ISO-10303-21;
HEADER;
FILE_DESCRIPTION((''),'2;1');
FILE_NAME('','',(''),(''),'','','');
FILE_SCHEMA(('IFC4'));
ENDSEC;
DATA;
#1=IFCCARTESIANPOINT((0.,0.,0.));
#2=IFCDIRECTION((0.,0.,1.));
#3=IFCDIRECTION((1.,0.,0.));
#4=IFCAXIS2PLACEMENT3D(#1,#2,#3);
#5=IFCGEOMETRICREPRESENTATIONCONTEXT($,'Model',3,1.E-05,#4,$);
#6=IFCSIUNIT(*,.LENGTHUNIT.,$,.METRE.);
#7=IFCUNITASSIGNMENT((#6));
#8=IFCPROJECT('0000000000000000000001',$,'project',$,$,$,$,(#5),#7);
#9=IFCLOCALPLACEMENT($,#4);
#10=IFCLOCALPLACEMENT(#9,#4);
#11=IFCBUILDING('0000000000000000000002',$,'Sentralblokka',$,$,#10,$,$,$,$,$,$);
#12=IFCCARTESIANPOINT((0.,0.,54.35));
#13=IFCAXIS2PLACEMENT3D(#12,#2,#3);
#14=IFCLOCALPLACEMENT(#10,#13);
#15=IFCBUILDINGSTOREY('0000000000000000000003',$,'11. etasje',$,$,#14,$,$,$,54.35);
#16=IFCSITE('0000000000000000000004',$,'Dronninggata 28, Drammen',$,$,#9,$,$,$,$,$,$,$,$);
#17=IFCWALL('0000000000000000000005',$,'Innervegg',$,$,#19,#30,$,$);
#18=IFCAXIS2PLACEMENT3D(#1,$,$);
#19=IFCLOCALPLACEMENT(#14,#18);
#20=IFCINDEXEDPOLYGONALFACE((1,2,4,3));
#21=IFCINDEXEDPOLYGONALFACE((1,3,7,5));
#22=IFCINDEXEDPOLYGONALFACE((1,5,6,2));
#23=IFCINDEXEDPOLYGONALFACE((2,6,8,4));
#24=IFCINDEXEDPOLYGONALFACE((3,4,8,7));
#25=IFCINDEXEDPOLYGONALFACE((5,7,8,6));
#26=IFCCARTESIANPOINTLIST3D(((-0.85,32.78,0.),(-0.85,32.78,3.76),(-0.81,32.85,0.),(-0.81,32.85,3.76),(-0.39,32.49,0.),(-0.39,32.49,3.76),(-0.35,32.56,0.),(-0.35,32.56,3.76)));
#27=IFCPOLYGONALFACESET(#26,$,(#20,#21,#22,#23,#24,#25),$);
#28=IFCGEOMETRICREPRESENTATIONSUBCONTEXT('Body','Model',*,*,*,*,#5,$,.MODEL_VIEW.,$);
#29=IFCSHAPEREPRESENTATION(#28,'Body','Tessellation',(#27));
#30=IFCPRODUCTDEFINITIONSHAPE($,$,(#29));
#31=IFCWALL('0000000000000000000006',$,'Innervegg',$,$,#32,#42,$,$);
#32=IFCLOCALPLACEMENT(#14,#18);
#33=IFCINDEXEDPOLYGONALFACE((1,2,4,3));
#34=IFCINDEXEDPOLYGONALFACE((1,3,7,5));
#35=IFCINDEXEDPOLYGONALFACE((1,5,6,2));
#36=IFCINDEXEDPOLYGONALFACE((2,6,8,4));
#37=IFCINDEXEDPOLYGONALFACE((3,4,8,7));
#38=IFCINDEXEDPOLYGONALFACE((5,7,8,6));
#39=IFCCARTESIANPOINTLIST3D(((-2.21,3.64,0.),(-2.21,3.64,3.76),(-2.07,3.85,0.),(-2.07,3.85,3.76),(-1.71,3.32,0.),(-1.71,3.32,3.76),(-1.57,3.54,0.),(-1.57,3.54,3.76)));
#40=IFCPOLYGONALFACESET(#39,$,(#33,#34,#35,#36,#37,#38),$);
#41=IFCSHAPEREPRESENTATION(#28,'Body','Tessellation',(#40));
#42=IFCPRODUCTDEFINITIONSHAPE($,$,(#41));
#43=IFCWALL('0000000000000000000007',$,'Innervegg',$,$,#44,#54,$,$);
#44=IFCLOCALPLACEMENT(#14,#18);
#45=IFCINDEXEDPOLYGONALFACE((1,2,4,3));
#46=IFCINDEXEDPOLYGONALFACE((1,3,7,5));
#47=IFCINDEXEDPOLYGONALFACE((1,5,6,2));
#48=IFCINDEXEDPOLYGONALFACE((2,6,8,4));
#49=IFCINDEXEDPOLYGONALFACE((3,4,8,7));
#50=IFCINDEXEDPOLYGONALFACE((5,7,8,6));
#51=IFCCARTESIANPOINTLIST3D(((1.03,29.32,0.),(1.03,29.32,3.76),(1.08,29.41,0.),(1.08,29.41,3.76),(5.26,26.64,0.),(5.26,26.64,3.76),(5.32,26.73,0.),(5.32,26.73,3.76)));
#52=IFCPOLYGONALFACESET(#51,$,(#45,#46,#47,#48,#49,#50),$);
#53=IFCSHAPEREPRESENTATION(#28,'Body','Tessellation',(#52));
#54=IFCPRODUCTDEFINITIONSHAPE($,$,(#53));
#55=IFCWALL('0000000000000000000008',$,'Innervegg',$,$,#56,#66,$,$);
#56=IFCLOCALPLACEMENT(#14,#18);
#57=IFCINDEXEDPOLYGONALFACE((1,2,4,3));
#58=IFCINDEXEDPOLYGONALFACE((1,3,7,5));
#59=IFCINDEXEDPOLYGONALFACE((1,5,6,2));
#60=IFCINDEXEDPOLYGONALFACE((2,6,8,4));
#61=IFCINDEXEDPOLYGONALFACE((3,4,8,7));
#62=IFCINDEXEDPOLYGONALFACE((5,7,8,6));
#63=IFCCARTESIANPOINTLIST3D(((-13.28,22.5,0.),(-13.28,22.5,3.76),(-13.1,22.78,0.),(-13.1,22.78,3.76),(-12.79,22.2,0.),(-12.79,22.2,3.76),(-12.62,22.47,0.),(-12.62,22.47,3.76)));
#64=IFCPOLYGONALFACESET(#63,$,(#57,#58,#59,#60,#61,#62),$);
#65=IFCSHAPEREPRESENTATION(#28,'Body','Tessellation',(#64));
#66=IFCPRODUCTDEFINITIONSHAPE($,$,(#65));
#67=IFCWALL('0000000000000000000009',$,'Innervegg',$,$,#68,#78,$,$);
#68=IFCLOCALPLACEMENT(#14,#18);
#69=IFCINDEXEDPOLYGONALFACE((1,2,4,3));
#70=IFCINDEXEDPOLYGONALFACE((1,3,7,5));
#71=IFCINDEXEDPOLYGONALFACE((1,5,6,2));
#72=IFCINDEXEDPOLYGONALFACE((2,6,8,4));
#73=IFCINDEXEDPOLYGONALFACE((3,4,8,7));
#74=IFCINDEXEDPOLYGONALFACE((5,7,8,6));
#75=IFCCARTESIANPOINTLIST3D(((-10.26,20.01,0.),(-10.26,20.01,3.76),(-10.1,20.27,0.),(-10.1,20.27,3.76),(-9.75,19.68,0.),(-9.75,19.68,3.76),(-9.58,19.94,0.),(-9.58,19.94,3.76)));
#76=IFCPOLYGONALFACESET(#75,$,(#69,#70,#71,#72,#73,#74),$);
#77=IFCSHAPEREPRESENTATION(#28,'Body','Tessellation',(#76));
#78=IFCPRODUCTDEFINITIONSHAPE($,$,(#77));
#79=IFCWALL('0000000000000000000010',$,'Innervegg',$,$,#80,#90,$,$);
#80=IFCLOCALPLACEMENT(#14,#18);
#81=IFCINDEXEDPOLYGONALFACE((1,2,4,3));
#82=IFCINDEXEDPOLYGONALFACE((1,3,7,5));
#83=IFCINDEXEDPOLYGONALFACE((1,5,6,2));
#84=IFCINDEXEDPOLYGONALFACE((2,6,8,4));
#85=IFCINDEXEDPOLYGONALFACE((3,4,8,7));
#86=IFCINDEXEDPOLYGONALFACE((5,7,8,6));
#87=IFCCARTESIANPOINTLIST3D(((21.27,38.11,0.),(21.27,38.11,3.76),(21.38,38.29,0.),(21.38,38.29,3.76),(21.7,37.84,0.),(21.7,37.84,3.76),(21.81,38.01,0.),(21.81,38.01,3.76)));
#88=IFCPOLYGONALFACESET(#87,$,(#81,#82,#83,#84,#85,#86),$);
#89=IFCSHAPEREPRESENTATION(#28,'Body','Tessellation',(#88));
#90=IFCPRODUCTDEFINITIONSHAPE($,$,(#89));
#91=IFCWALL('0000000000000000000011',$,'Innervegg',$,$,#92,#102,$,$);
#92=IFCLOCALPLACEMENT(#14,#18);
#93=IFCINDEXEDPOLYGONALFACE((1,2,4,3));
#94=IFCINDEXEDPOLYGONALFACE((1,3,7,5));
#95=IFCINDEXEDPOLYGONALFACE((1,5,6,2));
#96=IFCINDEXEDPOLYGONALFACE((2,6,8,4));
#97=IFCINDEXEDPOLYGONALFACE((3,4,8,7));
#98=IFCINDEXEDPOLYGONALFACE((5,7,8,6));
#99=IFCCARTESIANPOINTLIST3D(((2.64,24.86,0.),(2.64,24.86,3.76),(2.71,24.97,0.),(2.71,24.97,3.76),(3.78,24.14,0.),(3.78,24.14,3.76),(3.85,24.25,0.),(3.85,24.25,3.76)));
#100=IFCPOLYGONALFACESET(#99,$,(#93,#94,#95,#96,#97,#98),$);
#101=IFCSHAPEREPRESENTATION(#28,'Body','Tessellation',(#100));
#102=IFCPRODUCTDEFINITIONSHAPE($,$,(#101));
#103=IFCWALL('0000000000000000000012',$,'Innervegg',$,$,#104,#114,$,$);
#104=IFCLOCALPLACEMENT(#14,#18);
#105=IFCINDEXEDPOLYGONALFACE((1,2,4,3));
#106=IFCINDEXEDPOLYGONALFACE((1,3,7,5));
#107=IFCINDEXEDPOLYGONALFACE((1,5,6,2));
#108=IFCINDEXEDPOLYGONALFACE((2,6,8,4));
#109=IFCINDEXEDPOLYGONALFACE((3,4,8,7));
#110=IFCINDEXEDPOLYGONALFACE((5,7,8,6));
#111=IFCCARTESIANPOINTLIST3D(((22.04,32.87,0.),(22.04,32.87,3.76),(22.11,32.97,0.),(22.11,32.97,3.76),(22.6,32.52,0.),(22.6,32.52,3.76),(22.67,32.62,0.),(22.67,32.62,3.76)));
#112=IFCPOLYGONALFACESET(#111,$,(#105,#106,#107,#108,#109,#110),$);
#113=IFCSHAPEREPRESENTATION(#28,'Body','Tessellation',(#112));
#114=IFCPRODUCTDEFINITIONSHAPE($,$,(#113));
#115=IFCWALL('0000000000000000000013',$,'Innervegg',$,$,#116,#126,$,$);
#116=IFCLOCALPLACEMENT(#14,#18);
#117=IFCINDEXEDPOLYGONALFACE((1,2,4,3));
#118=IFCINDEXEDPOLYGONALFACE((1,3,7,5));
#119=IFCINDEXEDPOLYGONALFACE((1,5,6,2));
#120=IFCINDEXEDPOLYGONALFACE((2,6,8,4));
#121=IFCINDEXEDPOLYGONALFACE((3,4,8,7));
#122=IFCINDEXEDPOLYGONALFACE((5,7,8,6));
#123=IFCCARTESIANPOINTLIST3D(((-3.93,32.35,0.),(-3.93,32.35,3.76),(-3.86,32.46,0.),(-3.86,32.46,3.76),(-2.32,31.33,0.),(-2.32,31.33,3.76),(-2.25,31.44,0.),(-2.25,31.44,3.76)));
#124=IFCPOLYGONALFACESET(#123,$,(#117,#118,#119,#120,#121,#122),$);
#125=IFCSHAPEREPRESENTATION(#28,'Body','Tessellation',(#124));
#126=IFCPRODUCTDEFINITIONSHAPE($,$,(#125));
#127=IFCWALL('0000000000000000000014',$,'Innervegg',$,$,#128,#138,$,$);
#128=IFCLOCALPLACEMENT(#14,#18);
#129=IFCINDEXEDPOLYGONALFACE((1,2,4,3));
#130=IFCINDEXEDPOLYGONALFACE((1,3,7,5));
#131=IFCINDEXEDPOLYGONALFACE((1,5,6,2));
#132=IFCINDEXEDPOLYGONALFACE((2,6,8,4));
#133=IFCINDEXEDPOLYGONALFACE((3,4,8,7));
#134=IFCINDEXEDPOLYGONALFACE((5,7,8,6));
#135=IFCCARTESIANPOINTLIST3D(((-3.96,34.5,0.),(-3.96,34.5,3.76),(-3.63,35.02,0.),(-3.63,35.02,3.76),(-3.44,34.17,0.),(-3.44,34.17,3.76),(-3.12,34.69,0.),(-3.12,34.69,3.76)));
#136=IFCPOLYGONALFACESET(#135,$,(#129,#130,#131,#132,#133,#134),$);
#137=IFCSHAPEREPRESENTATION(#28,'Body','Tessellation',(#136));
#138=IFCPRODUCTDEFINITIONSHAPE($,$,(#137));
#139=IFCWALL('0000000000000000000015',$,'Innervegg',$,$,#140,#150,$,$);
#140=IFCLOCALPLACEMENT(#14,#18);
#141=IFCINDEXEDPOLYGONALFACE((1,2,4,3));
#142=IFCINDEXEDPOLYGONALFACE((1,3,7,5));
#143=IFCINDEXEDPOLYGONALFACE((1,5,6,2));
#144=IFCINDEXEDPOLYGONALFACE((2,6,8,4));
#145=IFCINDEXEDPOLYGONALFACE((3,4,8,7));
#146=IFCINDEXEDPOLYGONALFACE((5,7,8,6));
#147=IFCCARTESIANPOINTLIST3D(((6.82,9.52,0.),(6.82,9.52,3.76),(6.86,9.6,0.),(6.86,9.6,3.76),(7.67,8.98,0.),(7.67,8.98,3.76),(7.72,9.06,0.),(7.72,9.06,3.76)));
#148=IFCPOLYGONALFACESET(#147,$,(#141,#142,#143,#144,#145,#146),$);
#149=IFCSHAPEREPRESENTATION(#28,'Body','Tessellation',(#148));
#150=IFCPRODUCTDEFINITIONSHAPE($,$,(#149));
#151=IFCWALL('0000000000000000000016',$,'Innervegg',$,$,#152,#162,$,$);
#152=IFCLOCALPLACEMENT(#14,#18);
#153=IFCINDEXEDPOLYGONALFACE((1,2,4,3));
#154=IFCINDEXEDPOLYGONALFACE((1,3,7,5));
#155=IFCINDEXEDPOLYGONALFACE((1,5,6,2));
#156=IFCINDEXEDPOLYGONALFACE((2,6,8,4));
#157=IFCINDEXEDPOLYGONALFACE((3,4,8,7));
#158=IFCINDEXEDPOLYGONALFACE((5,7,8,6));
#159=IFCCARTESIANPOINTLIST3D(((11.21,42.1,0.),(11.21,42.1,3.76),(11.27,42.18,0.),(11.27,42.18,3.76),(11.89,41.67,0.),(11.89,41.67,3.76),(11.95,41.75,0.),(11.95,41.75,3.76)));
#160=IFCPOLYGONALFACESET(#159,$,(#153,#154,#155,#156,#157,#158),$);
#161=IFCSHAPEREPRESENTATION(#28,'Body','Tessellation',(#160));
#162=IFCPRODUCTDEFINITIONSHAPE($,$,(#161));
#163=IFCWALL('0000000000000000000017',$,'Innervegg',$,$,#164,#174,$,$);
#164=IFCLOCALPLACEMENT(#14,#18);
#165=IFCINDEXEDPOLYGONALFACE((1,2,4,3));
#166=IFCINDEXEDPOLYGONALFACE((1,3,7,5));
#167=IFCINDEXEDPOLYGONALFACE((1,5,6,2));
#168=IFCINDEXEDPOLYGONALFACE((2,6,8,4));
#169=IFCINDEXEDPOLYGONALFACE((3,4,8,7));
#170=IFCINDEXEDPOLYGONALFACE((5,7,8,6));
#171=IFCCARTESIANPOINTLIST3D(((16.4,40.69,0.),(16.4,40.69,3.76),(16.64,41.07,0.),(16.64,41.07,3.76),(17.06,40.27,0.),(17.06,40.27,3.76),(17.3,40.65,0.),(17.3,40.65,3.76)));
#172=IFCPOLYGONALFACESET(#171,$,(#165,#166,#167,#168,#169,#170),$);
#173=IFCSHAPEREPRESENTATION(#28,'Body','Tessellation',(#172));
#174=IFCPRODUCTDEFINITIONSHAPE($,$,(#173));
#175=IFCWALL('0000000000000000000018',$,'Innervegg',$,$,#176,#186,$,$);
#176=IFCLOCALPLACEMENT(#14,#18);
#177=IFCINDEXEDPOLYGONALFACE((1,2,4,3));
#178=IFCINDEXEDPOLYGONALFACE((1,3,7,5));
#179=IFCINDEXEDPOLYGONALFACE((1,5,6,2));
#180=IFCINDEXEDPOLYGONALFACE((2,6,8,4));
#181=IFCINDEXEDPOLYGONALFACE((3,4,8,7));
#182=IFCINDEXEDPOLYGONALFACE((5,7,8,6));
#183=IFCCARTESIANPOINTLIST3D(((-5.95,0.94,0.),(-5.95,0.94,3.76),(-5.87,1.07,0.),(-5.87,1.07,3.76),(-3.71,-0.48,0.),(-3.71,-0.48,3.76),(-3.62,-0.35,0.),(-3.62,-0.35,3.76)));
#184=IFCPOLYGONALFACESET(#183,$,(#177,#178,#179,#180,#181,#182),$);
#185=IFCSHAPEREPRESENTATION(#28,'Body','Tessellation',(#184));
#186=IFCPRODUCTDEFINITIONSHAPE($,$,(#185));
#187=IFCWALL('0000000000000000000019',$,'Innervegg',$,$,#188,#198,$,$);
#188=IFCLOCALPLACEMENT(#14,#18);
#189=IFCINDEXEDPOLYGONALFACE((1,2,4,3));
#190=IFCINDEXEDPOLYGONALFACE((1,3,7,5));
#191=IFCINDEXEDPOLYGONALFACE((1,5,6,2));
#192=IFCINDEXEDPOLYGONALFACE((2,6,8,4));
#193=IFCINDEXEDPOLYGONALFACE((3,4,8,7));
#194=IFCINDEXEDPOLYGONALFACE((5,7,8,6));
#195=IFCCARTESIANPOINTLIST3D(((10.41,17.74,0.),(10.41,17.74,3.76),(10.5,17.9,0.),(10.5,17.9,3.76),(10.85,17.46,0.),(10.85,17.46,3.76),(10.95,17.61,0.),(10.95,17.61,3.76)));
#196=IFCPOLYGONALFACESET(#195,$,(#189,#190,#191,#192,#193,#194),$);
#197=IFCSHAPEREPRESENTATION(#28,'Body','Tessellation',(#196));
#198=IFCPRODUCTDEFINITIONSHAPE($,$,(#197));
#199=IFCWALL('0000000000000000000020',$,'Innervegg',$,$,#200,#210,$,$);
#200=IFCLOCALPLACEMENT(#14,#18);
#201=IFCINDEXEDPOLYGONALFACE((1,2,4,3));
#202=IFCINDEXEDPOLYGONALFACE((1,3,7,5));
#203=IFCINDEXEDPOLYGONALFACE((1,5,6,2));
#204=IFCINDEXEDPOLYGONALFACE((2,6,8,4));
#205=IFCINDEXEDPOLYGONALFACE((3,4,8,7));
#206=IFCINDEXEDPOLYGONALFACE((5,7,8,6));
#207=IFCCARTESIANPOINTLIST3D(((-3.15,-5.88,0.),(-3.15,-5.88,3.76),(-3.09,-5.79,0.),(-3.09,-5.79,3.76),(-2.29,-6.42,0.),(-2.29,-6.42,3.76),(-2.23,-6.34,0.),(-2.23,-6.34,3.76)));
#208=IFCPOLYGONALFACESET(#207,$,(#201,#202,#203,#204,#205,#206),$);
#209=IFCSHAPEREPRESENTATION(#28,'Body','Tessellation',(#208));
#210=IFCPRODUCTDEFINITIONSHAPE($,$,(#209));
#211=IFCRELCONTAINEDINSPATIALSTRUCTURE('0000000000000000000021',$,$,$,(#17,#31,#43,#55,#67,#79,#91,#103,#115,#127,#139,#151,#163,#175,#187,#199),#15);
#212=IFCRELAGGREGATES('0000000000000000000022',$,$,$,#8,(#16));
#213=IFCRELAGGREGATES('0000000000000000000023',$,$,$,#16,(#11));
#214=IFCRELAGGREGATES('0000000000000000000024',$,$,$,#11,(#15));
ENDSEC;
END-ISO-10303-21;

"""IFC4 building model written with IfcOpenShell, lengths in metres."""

from ifc_helpers import new_model, si_unit, frame, origin_with_axes, place, context, subcontext, project, spatial, polyline, outline, extrude, element, save


model = new_model("IFC4")

# Units and contexts
model_context = context("Model", 3, precision=1e-05, world=origin_with_axes())
body_context = subcontext(model_context, "Body", "Model", "MODEL_VIEW")
ifc_project = project(units=[si_unit("LENGTHUNIT", "METRE")], contexts=[model_context])

# Site, building, storey
site_placement = place(None, origin_with_axes())
site = spatial("IfcSite", under=ifc_project, at=site_placement, Name="Dronninggata 28, Drammen")
building_placement = place(site_placement, origin_with_axes())
building = spatial("IfcBuilding", under=site, at=building_placement, Name="Sentralblokka")
storey_placement = place(building_placement, frame((0.0, 0.0, 54.35), z_axis=(0.0, 0.0, 1.0), x_axis=(1.0, 0.0, 0.0)))
storey = spatial("IfcBuildingStorey", under=building, at=storey_placement, Name="11. etasje", Elevation=54.35)

# Walls
wall_1_placement = place(storey_placement, frame((0.0, 0.0, -54.35), z_axis=(0.0, 0.0, 1.0), x_axis=(1.0, 0.0, 0.0)))
element("IfcWall", 1, at=wall_1_placement, inside=storey, Name="Innervegg", context=body_context, shape_type="SweptSolid", body=[
    extrude(outline(polyline([(-0.35, 32.56), (-0.39, 32.49), (-0.85, 32.78), (-0.81, 32.85), (-0.35, 32.56)])), frame((0.0, 0.0, 54.35)), (0.0, 0.0, 1.0), 3.76),
])
wall_2_placement = place(storey_placement, frame((0.0, 0.0, -54.35), z_axis=(0.0, 0.0, 1.0), x_axis=(1.0, 0.0, 0.0)))
element("IfcWall", 2, at=wall_2_placement, inside=storey, Name="Innervegg", context=body_context, shape_type="SweptSolid", body=[
    extrude(outline(polyline([(-1.57, 3.54), (-1.71, 3.32), (-2.21, 3.64), (-2.07, 3.85), (-1.57, 3.54)])), frame((0.0, 0.0, 54.35)), (0.0, 0.0, 1.0), 3.76),
])
wall_3_placement = place(storey_placement, frame((0.0, 0.0, -54.35), z_axis=(0.0, 0.0, 1.0), x_axis=(1.0, 0.0, 0.0)))
element("IfcWall", 3, at=wall_3_placement, inside=storey, Name="Innervegg", context=body_context, shape_type="SweptSolid", body=[
    extrude(outline(polyline([(5.32, 26.73), (5.26, 26.64), (1.03, 29.32), (1.08, 29.41), (5.32, 26.73)])), frame((0.0, 0.0, 54.35)), (0.0, 0.0, 1.0), 3.76),
])
wall_4_placement = place(storey_placement, frame((0.0, 0.0, -54.35), z_axis=(0.0, 0.0, 1.0), x_axis=(1.0, 0.0, 0.0)))
element("IfcWall", 4, at=wall_4_placement, inside=storey, Name="Innervegg", context=body_context, shape_type="SweptSolid", body=[
    extrude(outline(polyline([(-12.62, 22.47), (-12.79, 22.2), (-13.28, 22.5), (-13.1, 22.78), (-12.62, 22.47)])), frame((0.0, 0.0, 54.35)), (0.0, 0.0, 1.0), 3.76),
])
wall_5_placement = place(storey_placement, frame((0.0, 0.0, -54.35), z_axis=(0.0, 0.0, 1.0), x_axis=(1.0, 0.0, 0.0)))
element("IfcWall", 5, at=wall_5_placement, inside=storey, Name="Innervegg", context=body_context, shape_type="SweptSolid", body=[
    extrude(outline(polyline([(-9.58, 19.94), (-9.75, 19.68), (-10.26, 20.01), (-10.1, 20.27), (-9.58, 19.94)])), frame((0.0, 0.0, 54.35)), (0.0, 0.0, 1.0), 3.76),
])
wall_6_placement = place(storey_placement, frame((0.0, 0.0, -54.35), z_axis=(0.0, 0.0, 1.0), x_axis=(1.0, 0.0, 0.0)))
element("IfcWall", 6, at=wall_6_placement, inside=storey, Name="Innervegg", context=body_context, shape_type="SweptSolid", body=[
    extrude(outline(polyline([(21.81, 38.01), (21.7, 37.84), (21.27, 38.11), (21.38, 38.29), (21.81, 38.01)])), frame((0.0, 0.0, 54.35)), (0.0, 0.0, 1.0), 3.76),
])
wall_7_placement = place(storey_placement, frame((0.0, 0.0, -54.35), z_axis=(0.0, 0.0, 1.0), x_axis=(1.0, 0.0, 0.0)))
element("IfcWall", 7, at=wall_7_placement, inside=storey, Name="Innervegg", context=body_context, shape_type="SweptSolid", body=[
    extrude(outline(polyline([(3.85, 24.25), (3.78, 24.14), (2.64, 24.86), (2.71, 24.97), (3.85, 24.25)])), frame((0.0, 0.0, 54.35)), (0.0, 0.0, 1.0), 3.76),
])
wall_8_placement = place(storey_placement, frame((0.0, 0.0, -54.35), z_axis=(0.0, 0.0, 1.0), x_axis=(1.0, 0.0, 0.0)))
element("IfcWall", 8, at=wall_8_placement, inside=storey, Name="Innervegg", context=body_context, shape_type="SweptSolid", body=[
    extrude(outline(polyline([(22.67, 32.62), (22.6, 32.52), (22.04, 32.87), (22.11, 32.97), (22.67, 32.62)])), frame((0.0, 0.0, 54.35)), (0.0, 0.0, 1.0), 3.76),
])
wall_9_placement = place(storey_placement, frame((0.0, 0.0, -54.35), z_axis=(0.0, 0.0, 1.0), x_axis=(1.0, 0.0, 0.0)))
element("IfcWall", 9, at=wall_9_placement, inside=storey, Name="Innervegg", context=body_context, shape_type="SweptSolid", body=[
    extrude(outline(polyline([(-2.25, 31.44), (-2.32, 31.33), (-3.93, 32.35), (-3.86, 32.46), (-2.25, 31.44)])), frame((0.0, 0.0, 54.35)), (0.0, 0.0, 1.0), 3.76),
])
wall_10_placement = place(storey_placement, frame((0.0, 0.0, -54.35), z_axis=(0.0, 0.0, 1.0), x_axis=(1.0, 0.0, 0.0)))
element("IfcWall", 10, at=wall_10_placement, inside=storey, Name="Innervegg", context=body_context, shape_type="SweptSolid", body=[
    extrude(outline(polyline([(-3.12, 34.69), (-3.44, 34.17), (-3.96, 34.5), (-3.63, 35.02), (-3.12, 34.69)])), frame((0.0, 0.0, 54.35)), (0.0, 0.0, 1.0), 3.76),
])
wall_11_placement = place(storey_placement, frame((0.0, 0.0, -54.35), z_axis=(0.0, 0.0, 1.0), x_axis=(1.0, 0.0, 0.0)))
element("IfcWall", 11, at=wall_11_placement, inside=storey, Name="Innervegg", context=body_context, shape_type="SweptSolid", body=[
    extrude(outline(polyline([(7.72, 9.06), (7.67, 8.98), (6.82, 9.52), (6.86, 9.6), (7.72, 9.06)])), frame((0.0, 0.0, 54.35)), (0.0, 0.0, 1.0), 3.76),
])
wall_12_placement = place(storey_placement, frame((0.0, 0.0, -54.35), z_axis=(0.0, 0.0, 1.0), x_axis=(1.0, 0.0, 0.0)))
element("IfcWall", 12, at=wall_12_placement, inside=storey, Name="Innervegg", context=body_context, shape_type="SweptSolid", body=[
    extrude(outline(polyline([(11.95, 41.75), (11.89, 41.67), (11.21, 42.1), (11.27, 42.18), (11.95, 41.75)])), frame((0.0, 0.0, 54.35)), (0.0, 0.0, 1.0), 3.76),
])
wall_13_placement = place(storey_placement, frame((0.0, 0.0, -54.35), z_axis=(0.0, 0.0, 1.0), x_axis=(1.0, 0.0, 0.0)))
element("IfcWall", 13, at=wall_13_placement, inside=storey, Name="Innervegg", context=body_context, shape_type="SweptSolid", body=[
    extrude(outline(polyline([(17.3, 40.65), (17.06, 40.27), (16.4, 40.69), (16.64, 41.07), (17.3, 40.65)])), frame((0.0, 0.0, 54.35)), (0.0, 0.0, 1.0), 3.76),
])
wall_14_placement = place(storey_placement, frame((0.0, 0.0, -54.35), z_axis=(0.0, 0.0, 1.0), x_axis=(1.0, 0.0, 0.0)))
element("IfcWall", 14, at=wall_14_placement, inside=storey, Name="Innervegg", context=body_context, shape_type="SweptSolid", body=[
    extrude(outline(polyline([(-3.62, -0.35), (-3.71, -0.48), (-5.95, 0.94), (-5.87, 1.07), (-3.62, -0.35)])), frame((0.0, 0.0, 54.35)), (0.0, 0.0, 1.0), 3.76),
])
wall_15_placement = place(storey_placement, frame((0.0, 0.0, -54.35), z_axis=(0.0, 0.0, 1.0), x_axis=(1.0, 0.0, 0.0)))
element("IfcWall", 15, at=wall_15_placement, inside=storey, Name="Innervegg", context=body_context, shape_type="SweptSolid", body=[
    extrude(outline(polyline([(10.95, 17.61), (10.85, 17.46), (10.41, 17.74), (10.5, 17.9), (10.95, 17.61)])), frame((0.0, 0.0, 54.35)), (0.0, 0.0, 1.0), 3.76),
])
wall_16_placement = place(storey_placement, frame((0.0, 0.0, -54.35), z_axis=(0.0, 0.0, 1.0), x_axis=(1.0, 0.0, 0.0)))
element("IfcWall", 16, at=wall_16_placement, inside=storey, Name="Innervegg", context=body_context, shape_type="SweptSolid", body=[
    extrude(outline(polyline([(-2.23, -6.34), (-2.29, -6.42), (-3.15, -5.88), (-3.09, -5.79), (-2.23, -6.34)])), frame((0.0, 0.0, 54.35)), (0.0, 0.0, 1.0), 3.76),
])

save(model, "model.ifc")
